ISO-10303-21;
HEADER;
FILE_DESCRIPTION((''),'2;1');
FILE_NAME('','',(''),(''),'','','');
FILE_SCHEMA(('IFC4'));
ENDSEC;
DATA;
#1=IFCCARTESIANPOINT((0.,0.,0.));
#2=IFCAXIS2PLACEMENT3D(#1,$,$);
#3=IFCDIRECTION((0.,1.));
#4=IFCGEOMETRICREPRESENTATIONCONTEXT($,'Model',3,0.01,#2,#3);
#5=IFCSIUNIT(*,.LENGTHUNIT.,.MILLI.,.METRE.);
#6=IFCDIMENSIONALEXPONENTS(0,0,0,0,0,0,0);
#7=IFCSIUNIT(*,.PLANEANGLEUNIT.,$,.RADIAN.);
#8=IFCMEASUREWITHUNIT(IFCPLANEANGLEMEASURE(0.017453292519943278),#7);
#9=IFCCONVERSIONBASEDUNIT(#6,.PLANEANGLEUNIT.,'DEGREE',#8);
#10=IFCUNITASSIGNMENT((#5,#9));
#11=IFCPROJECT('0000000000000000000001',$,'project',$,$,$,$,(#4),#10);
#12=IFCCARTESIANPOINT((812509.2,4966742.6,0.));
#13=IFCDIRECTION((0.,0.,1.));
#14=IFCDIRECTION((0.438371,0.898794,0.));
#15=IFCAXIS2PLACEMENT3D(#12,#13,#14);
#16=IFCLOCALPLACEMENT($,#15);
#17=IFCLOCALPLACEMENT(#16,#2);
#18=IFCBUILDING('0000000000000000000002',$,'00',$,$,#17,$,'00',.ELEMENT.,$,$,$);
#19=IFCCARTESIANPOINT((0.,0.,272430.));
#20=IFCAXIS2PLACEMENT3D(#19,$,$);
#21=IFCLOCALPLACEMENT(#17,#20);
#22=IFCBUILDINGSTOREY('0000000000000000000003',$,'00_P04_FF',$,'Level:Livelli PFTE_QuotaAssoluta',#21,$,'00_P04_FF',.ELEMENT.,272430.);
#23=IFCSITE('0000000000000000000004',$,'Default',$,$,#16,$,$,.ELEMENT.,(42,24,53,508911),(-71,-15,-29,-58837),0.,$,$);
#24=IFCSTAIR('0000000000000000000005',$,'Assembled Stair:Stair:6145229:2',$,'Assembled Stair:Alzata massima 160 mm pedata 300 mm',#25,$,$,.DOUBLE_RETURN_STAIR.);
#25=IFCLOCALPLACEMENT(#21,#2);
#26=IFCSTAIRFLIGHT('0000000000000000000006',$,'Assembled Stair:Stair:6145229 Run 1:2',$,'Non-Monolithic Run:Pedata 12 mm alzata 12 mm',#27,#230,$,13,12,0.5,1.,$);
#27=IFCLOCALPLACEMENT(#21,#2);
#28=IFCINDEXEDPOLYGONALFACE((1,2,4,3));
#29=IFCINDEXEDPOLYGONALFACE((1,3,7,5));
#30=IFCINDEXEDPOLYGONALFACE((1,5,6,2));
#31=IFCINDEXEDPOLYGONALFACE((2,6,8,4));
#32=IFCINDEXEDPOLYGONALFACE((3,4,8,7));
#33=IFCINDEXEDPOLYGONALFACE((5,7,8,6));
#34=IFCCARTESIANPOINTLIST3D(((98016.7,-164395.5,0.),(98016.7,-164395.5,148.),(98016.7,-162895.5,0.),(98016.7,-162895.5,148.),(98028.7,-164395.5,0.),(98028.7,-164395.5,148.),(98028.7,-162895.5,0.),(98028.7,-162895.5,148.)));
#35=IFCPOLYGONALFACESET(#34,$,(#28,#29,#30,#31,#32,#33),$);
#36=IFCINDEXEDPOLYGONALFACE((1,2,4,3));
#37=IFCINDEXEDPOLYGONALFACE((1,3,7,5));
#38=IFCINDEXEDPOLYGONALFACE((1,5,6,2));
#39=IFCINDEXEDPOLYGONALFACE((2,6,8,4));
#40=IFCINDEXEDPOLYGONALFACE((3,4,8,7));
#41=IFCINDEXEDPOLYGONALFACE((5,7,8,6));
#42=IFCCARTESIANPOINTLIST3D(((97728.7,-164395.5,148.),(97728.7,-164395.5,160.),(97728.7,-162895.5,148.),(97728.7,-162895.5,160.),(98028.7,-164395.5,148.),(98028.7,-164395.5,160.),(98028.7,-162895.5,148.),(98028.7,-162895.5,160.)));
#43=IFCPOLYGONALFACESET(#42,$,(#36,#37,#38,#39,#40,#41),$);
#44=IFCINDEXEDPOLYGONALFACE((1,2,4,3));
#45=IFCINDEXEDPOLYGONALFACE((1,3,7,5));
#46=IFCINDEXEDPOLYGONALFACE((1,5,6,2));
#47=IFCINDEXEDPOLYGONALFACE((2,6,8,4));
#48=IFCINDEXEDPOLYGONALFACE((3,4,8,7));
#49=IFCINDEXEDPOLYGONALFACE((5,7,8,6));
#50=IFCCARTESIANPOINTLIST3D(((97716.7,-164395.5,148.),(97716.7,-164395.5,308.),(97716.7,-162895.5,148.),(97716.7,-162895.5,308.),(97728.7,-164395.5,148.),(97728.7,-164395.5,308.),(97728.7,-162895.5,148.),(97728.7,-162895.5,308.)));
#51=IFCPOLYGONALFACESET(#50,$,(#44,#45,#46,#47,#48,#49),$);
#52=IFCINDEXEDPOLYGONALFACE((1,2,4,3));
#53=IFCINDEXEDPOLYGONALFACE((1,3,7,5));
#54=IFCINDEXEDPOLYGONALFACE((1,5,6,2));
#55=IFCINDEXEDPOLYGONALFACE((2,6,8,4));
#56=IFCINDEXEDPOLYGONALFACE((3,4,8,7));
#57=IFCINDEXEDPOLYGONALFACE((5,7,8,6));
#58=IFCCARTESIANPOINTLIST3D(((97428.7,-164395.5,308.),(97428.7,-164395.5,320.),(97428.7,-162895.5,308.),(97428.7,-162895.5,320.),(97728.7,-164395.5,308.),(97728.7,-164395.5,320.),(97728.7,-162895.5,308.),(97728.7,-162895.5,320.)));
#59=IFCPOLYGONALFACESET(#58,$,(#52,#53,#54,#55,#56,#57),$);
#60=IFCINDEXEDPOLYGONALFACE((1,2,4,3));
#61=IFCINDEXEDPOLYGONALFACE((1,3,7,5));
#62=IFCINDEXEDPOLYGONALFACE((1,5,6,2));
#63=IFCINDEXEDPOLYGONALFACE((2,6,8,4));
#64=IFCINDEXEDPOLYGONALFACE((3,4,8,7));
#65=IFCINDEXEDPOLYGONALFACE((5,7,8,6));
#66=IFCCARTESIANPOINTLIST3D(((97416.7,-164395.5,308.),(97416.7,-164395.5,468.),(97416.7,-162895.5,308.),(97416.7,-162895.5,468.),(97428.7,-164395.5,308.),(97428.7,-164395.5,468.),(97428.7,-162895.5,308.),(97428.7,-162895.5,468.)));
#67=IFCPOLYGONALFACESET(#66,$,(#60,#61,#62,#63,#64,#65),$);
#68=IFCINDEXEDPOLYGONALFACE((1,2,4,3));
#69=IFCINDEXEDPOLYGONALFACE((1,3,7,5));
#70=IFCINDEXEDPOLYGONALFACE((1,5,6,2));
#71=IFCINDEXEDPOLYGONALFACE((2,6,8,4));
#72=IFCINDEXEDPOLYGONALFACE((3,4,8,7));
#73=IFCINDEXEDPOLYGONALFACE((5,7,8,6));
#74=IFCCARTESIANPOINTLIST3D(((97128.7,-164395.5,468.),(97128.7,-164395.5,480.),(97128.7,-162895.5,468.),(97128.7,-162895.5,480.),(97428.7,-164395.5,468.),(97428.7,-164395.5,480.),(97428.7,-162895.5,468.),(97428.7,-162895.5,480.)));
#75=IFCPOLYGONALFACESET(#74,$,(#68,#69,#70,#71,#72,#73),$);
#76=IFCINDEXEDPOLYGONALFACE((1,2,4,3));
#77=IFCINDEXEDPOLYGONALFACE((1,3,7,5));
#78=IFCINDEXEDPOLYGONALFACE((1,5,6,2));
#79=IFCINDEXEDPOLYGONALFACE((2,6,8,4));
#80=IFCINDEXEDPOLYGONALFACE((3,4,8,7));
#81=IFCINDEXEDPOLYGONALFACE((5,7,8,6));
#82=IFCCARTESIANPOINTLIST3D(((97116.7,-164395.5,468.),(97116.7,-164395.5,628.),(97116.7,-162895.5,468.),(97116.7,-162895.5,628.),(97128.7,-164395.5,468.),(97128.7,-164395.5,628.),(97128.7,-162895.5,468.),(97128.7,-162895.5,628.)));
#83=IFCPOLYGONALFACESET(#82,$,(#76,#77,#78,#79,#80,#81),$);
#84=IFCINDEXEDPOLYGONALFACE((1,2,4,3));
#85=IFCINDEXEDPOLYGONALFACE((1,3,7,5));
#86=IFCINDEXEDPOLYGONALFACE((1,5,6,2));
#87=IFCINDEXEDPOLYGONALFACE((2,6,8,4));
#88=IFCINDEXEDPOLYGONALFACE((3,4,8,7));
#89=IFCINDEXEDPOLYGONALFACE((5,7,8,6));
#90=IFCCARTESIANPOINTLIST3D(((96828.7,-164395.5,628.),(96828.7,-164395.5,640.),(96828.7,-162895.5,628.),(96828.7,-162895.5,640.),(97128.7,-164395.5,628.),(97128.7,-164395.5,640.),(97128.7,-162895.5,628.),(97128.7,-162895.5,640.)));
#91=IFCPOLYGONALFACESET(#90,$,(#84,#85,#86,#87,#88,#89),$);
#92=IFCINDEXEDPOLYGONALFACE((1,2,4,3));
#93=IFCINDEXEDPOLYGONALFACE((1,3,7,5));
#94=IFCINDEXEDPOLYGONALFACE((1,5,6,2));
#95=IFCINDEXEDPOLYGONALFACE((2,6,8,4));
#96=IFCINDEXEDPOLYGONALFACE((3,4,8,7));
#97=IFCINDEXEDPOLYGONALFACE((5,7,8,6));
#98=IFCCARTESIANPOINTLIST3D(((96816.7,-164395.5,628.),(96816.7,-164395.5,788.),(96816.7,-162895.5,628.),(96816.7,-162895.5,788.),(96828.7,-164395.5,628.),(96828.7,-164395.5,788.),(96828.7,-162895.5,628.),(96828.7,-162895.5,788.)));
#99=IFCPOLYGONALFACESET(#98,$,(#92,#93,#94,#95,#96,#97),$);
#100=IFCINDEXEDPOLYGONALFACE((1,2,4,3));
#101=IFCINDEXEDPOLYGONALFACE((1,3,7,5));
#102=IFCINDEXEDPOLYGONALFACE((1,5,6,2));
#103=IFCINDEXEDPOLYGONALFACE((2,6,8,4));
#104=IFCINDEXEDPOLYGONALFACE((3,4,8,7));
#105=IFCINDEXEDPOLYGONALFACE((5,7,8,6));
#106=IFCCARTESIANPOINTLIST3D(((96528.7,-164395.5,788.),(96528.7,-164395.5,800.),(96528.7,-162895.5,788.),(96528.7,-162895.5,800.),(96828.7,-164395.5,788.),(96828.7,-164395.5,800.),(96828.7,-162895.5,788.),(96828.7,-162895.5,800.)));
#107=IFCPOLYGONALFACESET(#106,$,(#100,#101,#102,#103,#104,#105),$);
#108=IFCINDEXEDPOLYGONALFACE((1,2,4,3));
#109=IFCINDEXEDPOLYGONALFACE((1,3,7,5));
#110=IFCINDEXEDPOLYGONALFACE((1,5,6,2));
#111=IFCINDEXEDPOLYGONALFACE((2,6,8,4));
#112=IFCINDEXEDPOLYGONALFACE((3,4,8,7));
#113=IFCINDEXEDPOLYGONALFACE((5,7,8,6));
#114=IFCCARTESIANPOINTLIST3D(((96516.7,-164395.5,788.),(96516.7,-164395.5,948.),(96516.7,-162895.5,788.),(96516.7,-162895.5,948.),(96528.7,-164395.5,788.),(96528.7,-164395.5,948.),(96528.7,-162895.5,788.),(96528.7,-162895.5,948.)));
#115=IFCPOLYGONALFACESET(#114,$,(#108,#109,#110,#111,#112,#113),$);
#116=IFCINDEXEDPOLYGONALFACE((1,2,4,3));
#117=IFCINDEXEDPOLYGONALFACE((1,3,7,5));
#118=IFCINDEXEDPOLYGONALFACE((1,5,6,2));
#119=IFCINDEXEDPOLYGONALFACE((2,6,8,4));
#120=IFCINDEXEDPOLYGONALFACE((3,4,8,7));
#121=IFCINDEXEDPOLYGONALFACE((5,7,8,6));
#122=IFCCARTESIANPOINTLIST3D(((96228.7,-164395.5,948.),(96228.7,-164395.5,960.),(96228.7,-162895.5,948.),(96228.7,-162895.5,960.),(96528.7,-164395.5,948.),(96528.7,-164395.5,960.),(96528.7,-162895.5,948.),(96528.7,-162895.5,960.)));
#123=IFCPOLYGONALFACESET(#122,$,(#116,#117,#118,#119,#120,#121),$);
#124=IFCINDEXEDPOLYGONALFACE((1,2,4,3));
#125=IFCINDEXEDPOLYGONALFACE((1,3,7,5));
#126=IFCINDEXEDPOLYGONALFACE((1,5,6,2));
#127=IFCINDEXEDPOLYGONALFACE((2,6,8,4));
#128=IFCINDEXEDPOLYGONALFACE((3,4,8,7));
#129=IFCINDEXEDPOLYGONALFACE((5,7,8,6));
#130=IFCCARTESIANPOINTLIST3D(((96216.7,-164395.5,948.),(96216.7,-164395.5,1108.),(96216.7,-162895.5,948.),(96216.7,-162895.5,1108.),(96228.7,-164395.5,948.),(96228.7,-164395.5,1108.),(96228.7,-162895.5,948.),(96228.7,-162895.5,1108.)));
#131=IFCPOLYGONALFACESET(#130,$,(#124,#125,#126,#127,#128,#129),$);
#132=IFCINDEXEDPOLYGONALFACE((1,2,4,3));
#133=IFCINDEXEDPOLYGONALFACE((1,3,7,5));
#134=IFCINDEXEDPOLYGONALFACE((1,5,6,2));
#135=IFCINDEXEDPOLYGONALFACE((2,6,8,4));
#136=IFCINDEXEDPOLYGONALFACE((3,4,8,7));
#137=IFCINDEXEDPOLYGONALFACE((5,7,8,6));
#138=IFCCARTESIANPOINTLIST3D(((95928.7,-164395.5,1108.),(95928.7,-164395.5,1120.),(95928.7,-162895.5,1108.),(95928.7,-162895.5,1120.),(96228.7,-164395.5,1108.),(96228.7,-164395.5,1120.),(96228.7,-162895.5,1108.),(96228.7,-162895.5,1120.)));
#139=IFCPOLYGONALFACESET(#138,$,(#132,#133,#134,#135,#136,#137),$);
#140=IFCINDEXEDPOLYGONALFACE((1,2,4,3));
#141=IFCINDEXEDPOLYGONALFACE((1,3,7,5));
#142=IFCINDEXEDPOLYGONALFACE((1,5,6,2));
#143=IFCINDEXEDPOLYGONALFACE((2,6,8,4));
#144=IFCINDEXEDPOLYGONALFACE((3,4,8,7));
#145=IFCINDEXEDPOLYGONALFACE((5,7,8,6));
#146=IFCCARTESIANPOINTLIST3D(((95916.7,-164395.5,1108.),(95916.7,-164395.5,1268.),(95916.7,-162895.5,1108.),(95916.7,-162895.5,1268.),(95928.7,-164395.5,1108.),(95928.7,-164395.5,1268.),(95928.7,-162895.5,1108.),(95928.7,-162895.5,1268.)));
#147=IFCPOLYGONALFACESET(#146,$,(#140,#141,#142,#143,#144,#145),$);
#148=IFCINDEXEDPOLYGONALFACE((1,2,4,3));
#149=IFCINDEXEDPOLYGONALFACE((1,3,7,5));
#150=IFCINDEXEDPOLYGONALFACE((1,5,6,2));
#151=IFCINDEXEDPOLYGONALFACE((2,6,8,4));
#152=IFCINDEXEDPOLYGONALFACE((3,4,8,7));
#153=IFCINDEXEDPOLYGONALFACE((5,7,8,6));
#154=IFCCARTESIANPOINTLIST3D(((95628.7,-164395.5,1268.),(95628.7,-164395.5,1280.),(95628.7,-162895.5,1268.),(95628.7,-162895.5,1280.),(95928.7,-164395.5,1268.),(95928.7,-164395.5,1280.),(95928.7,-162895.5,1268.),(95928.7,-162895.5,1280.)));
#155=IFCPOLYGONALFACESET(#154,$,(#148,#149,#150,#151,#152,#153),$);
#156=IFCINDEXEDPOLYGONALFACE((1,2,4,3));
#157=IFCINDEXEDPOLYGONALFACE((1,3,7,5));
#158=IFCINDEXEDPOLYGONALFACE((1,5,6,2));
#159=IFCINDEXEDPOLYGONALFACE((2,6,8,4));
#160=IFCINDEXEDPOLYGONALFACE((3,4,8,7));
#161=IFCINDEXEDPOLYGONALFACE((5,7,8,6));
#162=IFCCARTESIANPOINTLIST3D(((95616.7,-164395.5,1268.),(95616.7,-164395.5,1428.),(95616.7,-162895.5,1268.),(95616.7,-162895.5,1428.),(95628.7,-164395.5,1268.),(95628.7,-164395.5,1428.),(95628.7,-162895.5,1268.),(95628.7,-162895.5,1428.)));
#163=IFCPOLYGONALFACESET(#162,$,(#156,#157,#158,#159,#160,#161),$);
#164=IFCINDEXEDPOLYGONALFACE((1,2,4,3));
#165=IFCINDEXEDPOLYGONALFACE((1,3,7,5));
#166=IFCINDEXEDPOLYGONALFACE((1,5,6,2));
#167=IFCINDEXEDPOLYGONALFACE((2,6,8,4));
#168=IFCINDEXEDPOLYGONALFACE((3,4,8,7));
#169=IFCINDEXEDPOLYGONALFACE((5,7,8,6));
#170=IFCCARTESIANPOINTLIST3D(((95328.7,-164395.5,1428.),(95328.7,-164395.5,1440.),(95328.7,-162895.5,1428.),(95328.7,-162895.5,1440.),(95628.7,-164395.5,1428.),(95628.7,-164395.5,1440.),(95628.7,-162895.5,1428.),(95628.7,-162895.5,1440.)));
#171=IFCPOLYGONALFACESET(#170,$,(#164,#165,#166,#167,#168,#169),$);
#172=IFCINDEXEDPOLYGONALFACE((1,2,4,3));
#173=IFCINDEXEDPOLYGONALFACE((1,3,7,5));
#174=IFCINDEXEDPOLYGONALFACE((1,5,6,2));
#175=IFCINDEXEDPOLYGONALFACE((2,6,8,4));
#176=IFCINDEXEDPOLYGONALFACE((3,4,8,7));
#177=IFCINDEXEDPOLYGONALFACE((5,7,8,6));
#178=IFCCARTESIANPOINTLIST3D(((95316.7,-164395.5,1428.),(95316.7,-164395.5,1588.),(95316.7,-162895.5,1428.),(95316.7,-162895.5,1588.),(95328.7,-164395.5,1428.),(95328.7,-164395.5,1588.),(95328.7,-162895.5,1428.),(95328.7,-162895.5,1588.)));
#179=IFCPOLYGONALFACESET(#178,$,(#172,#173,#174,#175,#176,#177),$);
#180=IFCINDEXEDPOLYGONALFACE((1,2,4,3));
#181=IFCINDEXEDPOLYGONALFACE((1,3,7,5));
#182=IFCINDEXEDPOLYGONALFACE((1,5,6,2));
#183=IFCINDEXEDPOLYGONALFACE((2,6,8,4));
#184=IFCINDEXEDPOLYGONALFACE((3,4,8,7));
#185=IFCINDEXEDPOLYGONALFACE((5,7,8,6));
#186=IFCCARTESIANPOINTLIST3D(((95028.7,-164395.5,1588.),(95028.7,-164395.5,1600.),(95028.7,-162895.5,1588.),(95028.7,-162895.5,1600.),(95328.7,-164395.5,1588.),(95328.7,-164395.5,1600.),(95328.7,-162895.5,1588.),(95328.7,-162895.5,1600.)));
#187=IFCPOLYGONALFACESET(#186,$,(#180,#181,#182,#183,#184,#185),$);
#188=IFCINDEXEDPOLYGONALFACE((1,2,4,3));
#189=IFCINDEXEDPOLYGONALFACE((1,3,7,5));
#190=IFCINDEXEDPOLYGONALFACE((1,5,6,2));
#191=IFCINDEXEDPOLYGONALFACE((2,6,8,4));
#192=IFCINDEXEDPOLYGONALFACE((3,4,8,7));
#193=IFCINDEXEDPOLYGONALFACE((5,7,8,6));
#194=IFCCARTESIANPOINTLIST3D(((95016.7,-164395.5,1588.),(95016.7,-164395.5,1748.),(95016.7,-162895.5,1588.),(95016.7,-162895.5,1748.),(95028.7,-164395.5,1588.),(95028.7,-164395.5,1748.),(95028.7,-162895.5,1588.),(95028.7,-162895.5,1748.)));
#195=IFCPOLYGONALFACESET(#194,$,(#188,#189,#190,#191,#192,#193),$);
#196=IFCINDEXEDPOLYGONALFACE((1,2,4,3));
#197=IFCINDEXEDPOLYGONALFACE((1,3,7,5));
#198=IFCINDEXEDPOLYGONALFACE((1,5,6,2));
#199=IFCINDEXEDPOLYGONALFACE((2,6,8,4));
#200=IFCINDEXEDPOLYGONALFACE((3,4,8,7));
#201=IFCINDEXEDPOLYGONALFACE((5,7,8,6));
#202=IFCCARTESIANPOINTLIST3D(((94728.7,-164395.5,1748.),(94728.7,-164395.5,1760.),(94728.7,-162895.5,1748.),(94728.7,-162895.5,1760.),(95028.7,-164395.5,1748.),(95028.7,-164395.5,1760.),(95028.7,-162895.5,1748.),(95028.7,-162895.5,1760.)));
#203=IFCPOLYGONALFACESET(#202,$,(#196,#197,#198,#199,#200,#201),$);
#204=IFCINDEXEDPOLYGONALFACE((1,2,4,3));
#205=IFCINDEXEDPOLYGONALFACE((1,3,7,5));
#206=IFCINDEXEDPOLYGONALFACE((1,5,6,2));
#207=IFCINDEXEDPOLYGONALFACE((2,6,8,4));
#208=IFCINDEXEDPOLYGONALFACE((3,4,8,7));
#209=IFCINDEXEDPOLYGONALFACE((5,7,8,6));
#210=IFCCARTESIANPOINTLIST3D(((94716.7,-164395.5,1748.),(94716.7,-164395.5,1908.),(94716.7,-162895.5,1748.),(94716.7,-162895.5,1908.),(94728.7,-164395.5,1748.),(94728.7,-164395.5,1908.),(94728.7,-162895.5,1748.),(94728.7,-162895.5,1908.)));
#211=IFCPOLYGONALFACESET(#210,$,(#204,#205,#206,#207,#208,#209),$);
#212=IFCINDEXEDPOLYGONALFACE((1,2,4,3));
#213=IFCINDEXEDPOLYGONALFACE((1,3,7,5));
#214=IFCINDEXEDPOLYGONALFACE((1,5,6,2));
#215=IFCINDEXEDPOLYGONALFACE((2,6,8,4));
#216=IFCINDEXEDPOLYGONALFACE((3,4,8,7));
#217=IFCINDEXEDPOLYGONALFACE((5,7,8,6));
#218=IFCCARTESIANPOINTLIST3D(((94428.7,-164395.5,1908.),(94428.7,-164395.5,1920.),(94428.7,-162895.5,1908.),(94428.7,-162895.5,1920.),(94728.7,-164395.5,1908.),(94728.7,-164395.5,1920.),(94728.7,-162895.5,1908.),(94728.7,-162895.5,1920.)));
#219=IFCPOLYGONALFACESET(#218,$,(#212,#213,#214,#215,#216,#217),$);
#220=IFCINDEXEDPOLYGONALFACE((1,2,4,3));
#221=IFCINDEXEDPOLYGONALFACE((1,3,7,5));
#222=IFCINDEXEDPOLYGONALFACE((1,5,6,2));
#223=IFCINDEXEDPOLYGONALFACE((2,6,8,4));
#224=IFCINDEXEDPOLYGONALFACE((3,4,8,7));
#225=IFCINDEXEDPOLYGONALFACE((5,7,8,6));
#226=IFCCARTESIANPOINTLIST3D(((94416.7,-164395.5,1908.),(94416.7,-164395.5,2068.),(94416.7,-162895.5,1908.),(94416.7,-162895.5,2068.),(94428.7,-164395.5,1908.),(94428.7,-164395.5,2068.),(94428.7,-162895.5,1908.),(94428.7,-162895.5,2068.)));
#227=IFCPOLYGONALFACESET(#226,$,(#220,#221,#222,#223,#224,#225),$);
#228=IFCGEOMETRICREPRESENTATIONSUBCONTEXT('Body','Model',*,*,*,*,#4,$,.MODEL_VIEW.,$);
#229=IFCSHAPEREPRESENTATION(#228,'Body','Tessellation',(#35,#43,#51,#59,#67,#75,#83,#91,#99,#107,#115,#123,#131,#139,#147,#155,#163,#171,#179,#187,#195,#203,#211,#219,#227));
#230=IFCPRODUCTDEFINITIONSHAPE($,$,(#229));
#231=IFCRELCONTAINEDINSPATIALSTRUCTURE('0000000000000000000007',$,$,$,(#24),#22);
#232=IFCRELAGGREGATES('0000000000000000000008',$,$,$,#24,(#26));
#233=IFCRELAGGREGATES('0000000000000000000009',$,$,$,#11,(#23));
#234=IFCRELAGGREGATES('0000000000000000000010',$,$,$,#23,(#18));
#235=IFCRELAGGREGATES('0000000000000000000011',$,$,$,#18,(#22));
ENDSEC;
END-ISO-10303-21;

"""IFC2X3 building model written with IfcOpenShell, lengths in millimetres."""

from ifc_helpers import new_model, entity, si_unit, converted_unit, direction, frame, origin, origin_2d_with_axis, place, context, subcontext, project, spatial, rectangle, extrude, element, aggregate, save


model = new_model("IFC2X3")

# Units and contexts
model_context = context("Model", 3, precision=0.01, world=origin(), true_north=direction((0.0, 1.0)))
body_context = subcontext(model_context, "Body", "Model", "MODEL_VIEW")
ifc_project = project(units=[si_unit("LENGTHUNIT", "METRE", prefix="MILLI"), converted_unit("PLANEANGLEUNIT", "DEGREE", entity("IfcPlaneAngleMeasure", 0.017453292519943278), si_unit("PLANEANGLEUNIT", "RADIAN"), dimensions=[0, 0, 0, 0, 0, 0, 0])], contexts=[model_context])

# Site, building, storey
site_placement = place(None, frame((812509.2, 4966742.6, 0.0), z_axis=(0.0, 0.0, 1.0), x_axis=(0.438371, 0.898794, 0.0)))
site = spatial("IfcSite", under=ifc_project, at=site_placement, Name="Default", CompositionType="ELEMENT", RefLatitude=(42, 24, 53, 508911), RefLongitude=(-71, -15, -29, -58837), RefElevation=0.0)
building_placement = place(site_placement, origin())
building = spatial("IfcBuilding", under=site, at=building_placement, Name="00", LongName="00", CompositionType="ELEMENT")
storey_placement = place(building_placement, frame((0.0, 0.0, 272430.0)))
storey = spatial("IfcBuildingStorey", under=building, at=storey_placement, Name="00_P04_FF", ObjectType="Level:Livelli PFTE_QuotaAssoluta", LongName="00_P04_FF", CompositionType="ELEMENT", Elevation=272430.0)

# Stair
stair_1_placement = place(storey_placement, origin())
stair_1 = element("IfcStair", 1, at=stair_1_placement, inside=storey, Name="Assembled Stair:Stair:6145229:2", ObjectType="Assembled Stair:Alzata massima 160 mm pedata 300 mm", ShapeType="DOUBLE_RETURN_STAIR")

# Stair flight
stair_flight_1_placement = place(stair_1_placement, origin())
stair_flight_1 = element("IfcStairFlight", 2, at=stair_flight_1_placement, Name="Assembled Stair:Stair:6145229 Run 1:2", ObjectType="Non-Monolithic Run:Pedata 12 mm alzata 12 mm", NumberOfRiser=13, NumberOfTreads=12, RiserHeight=0.5, TreadLength=1.0, context=body_context, shape_type="SweptSolid", body=[
    extrude(rectangle(XDim=1500.0, YDim=12.0, at=origin_2d_with_axis()), frame((98022.7, -163645.5, 0.0), z_axis=(0.0, 0.0, 1.0), x_axis=(0.0, -1.0, 0.0)), (0.0, 0.0, 1.0), 148.0),
    extrude(rectangle(XDim=300.0, YDim=1500.0, at=origin_2d_with_axis()), frame((97878.7, -163645.5, 148.0)), (0.0, 0.0, 1.0), 12.0),
    extrude(rectangle(XDim=1500.0, YDim=12.0, at=origin_2d_with_axis()), frame((97722.7, -163645.5, 148.0), z_axis=(0.0, 0.0, 1.0), x_axis=(0.0, -1.0, 0.0)), (0.0, 0.0, 1.0), 160.0),
    extrude(rectangle(XDim=300.0, YDim=1500.0, at=origin_2d_with_axis()), frame((97578.7, -163645.5, 308.0)), (0.0, 0.0, 1.0), 12.0),
    extrude(rectangle(XDim=1500.0, YDim=12.0, at=origin_2d_with_axis()), frame((97422.7, -163645.5, 308.0), z_axis=(0.0, 0.0, 1.0), x_axis=(0.0, -1.0, 0.0)), (0.0, 0.0, 1.0), 160.0),
    extrude(rectangle(XDim=300.0, YDim=1500.0, at=origin_2d_with_axis()), frame((97278.7, -163645.5, 468.0)), (0.0, 0.0, 1.0), 12.0),
    extrude(rectangle(XDim=1500.0, YDim=12.0, at=origin_2d_with_axis()), frame((97122.7, -163645.5, 468.0), z_axis=(0.0, 0.0, 1.0), x_axis=(0.0, -1.0, 0.0)), (0.0, 0.0, 1.0), 160.0),
    extrude(rectangle(XDim=300.0, YDim=1500.0, at=origin_2d_with_axis()), frame((96978.7, -163645.5, 628.0)), (0.0, 0.0, 1.0), 12.0),
    extrude(rectangle(XDim=1500.0, YDim=12.0, at=origin_2d_with_axis()), frame((96822.7, -163645.5, 628.0), z_axis=(0.0, 0.0, 1.0), x_axis=(0.0, -1.0, 0.0)), (0.0, 0.0, 1.0), 160.0),
    extrude(rectangle(XDim=300.0, YDim=1500.0, at=origin_2d_with_axis()), frame((96678.7, -163645.5, 788.0)), (0.0, 0.0, 1.0), 12.0),
    extrude(rectangle(XDim=1500.0, YDim=12.0, at=origin_2d_with_axis()), frame((96522.7, -163645.5, 788.0), z_axis=(0.0, 0.0, 1.0), x_axis=(0.0, -1.0, 0.0)), (0.0, 0.0, 1.0), 160.0),
    extrude(rectangle(XDim=300.0, YDim=1500.0, at=origin_2d_with_axis()), frame((96378.7, -163645.5, 948.0)), (0.0, 0.0, 1.0), 12.0),
    extrude(rectangle(XDim=1500.0, YDim=12.0, at=origin_2d_with_axis()), frame((96222.7, -163645.5, 948.0), z_axis=(0.0, 0.0, 1.0), x_axis=(0.0, -1.0, 0.0)), (0.0, 0.0, 1.0), 160.0),
    extrude(rectangle(XDim=300.0, YDim=1500.0, at=origin_2d_with_axis()), frame((96078.7, -163645.5, 1108.0)), (0.0, 0.0, 1.0), 12.0),
    extrude(rectangle(XDim=1500.0, YDim=12.0, at=origin_2d_with_axis()), frame((95922.7, -163645.5, 1108.0), z_axis=(0.0, 0.0, 1.0), x_axis=(0.0, -1.0, 0.0)), (0.0, 0.0, 1.0), 160.0),
    extrude(rectangle(XDim=300.0, YDim=1500.0, at=origin_2d_with_axis()), frame((95778.7, -163645.5, 1268.0)), (0.0, 0.0, 1.0), 12.0),
    extrude(rectangle(XDim=1500.0, YDim=12.0, at=origin_2d_with_axis()), frame((95622.7, -163645.5, 1268.0), z_axis=(0.0, 0.0, 1.0), x_axis=(0.0, -1.0, 0.0)), (0.0, 0.0, 1.0), 160.0),
    extrude(rectangle(XDim=300.0, YDim=1500.0, at=origin_2d_with_axis()), frame((95478.7, -163645.5, 1428.0)), (0.0, 0.0, 1.0), 12.0),
    extrude(rectangle(XDim=1500.0, YDim=12.0, at=origin_2d_with_axis()), frame((95322.7, -163645.5, 1428.0), z_axis=(0.0, 0.0, 1.0), x_axis=(0.0, -1.0, 0.0)), (0.0, 0.0, 1.0), 160.0),
    extrude(rectangle(XDim=300.0, YDim=1500.0, at=origin_2d_with_axis()), frame((95178.7, -163645.5, 1588.0)), (0.0, 0.0, 1.0), 12.0),
    extrude(rectangle(XDim=1500.0, YDim=12.0, at=origin_2d_with_axis()), frame((95022.7, -163645.5, 1588.0), z_axis=(0.0, 0.0, 1.0), x_axis=(0.0, -1.0, 0.0)), (0.0, 0.0, 1.0), 160.0),
    extrude(rectangle(XDim=300.0, YDim=1500.0, at=origin_2d_with_axis()), frame((94878.7, -163645.5, 1748.0)), (0.0, 0.0, 1.0), 12.0),
    extrude(rectangle(XDim=1500.0, YDim=12.0, at=origin_2d_with_axis()), frame((94722.7, -163645.5, 1748.0), z_axis=(0.0, 0.0, 1.0), x_axis=(0.0, -1.0, 0.0)), (0.0, 0.0, 1.0), 160.0),
    extrude(rectangle(XDim=300.0, YDim=1500.0, at=origin_2d_with_axis()), frame((94578.7, -163645.5, 1908.0)), (0.0, 0.0, 1.0), 12.0),
    extrude(rectangle(XDim=1500.0, YDim=12.0, at=origin_2d_with_axis()), frame((94422.7, -163645.5, 1908.0), z_axis=(0.0, 0.0, 1.0), x_axis=(0.0, -1.0, 0.0)), (0.0, 0.0, 1.0), 160.0),
])
aggregate(stair_1, [stair_flight_1])

save(model, "model.ifc")
